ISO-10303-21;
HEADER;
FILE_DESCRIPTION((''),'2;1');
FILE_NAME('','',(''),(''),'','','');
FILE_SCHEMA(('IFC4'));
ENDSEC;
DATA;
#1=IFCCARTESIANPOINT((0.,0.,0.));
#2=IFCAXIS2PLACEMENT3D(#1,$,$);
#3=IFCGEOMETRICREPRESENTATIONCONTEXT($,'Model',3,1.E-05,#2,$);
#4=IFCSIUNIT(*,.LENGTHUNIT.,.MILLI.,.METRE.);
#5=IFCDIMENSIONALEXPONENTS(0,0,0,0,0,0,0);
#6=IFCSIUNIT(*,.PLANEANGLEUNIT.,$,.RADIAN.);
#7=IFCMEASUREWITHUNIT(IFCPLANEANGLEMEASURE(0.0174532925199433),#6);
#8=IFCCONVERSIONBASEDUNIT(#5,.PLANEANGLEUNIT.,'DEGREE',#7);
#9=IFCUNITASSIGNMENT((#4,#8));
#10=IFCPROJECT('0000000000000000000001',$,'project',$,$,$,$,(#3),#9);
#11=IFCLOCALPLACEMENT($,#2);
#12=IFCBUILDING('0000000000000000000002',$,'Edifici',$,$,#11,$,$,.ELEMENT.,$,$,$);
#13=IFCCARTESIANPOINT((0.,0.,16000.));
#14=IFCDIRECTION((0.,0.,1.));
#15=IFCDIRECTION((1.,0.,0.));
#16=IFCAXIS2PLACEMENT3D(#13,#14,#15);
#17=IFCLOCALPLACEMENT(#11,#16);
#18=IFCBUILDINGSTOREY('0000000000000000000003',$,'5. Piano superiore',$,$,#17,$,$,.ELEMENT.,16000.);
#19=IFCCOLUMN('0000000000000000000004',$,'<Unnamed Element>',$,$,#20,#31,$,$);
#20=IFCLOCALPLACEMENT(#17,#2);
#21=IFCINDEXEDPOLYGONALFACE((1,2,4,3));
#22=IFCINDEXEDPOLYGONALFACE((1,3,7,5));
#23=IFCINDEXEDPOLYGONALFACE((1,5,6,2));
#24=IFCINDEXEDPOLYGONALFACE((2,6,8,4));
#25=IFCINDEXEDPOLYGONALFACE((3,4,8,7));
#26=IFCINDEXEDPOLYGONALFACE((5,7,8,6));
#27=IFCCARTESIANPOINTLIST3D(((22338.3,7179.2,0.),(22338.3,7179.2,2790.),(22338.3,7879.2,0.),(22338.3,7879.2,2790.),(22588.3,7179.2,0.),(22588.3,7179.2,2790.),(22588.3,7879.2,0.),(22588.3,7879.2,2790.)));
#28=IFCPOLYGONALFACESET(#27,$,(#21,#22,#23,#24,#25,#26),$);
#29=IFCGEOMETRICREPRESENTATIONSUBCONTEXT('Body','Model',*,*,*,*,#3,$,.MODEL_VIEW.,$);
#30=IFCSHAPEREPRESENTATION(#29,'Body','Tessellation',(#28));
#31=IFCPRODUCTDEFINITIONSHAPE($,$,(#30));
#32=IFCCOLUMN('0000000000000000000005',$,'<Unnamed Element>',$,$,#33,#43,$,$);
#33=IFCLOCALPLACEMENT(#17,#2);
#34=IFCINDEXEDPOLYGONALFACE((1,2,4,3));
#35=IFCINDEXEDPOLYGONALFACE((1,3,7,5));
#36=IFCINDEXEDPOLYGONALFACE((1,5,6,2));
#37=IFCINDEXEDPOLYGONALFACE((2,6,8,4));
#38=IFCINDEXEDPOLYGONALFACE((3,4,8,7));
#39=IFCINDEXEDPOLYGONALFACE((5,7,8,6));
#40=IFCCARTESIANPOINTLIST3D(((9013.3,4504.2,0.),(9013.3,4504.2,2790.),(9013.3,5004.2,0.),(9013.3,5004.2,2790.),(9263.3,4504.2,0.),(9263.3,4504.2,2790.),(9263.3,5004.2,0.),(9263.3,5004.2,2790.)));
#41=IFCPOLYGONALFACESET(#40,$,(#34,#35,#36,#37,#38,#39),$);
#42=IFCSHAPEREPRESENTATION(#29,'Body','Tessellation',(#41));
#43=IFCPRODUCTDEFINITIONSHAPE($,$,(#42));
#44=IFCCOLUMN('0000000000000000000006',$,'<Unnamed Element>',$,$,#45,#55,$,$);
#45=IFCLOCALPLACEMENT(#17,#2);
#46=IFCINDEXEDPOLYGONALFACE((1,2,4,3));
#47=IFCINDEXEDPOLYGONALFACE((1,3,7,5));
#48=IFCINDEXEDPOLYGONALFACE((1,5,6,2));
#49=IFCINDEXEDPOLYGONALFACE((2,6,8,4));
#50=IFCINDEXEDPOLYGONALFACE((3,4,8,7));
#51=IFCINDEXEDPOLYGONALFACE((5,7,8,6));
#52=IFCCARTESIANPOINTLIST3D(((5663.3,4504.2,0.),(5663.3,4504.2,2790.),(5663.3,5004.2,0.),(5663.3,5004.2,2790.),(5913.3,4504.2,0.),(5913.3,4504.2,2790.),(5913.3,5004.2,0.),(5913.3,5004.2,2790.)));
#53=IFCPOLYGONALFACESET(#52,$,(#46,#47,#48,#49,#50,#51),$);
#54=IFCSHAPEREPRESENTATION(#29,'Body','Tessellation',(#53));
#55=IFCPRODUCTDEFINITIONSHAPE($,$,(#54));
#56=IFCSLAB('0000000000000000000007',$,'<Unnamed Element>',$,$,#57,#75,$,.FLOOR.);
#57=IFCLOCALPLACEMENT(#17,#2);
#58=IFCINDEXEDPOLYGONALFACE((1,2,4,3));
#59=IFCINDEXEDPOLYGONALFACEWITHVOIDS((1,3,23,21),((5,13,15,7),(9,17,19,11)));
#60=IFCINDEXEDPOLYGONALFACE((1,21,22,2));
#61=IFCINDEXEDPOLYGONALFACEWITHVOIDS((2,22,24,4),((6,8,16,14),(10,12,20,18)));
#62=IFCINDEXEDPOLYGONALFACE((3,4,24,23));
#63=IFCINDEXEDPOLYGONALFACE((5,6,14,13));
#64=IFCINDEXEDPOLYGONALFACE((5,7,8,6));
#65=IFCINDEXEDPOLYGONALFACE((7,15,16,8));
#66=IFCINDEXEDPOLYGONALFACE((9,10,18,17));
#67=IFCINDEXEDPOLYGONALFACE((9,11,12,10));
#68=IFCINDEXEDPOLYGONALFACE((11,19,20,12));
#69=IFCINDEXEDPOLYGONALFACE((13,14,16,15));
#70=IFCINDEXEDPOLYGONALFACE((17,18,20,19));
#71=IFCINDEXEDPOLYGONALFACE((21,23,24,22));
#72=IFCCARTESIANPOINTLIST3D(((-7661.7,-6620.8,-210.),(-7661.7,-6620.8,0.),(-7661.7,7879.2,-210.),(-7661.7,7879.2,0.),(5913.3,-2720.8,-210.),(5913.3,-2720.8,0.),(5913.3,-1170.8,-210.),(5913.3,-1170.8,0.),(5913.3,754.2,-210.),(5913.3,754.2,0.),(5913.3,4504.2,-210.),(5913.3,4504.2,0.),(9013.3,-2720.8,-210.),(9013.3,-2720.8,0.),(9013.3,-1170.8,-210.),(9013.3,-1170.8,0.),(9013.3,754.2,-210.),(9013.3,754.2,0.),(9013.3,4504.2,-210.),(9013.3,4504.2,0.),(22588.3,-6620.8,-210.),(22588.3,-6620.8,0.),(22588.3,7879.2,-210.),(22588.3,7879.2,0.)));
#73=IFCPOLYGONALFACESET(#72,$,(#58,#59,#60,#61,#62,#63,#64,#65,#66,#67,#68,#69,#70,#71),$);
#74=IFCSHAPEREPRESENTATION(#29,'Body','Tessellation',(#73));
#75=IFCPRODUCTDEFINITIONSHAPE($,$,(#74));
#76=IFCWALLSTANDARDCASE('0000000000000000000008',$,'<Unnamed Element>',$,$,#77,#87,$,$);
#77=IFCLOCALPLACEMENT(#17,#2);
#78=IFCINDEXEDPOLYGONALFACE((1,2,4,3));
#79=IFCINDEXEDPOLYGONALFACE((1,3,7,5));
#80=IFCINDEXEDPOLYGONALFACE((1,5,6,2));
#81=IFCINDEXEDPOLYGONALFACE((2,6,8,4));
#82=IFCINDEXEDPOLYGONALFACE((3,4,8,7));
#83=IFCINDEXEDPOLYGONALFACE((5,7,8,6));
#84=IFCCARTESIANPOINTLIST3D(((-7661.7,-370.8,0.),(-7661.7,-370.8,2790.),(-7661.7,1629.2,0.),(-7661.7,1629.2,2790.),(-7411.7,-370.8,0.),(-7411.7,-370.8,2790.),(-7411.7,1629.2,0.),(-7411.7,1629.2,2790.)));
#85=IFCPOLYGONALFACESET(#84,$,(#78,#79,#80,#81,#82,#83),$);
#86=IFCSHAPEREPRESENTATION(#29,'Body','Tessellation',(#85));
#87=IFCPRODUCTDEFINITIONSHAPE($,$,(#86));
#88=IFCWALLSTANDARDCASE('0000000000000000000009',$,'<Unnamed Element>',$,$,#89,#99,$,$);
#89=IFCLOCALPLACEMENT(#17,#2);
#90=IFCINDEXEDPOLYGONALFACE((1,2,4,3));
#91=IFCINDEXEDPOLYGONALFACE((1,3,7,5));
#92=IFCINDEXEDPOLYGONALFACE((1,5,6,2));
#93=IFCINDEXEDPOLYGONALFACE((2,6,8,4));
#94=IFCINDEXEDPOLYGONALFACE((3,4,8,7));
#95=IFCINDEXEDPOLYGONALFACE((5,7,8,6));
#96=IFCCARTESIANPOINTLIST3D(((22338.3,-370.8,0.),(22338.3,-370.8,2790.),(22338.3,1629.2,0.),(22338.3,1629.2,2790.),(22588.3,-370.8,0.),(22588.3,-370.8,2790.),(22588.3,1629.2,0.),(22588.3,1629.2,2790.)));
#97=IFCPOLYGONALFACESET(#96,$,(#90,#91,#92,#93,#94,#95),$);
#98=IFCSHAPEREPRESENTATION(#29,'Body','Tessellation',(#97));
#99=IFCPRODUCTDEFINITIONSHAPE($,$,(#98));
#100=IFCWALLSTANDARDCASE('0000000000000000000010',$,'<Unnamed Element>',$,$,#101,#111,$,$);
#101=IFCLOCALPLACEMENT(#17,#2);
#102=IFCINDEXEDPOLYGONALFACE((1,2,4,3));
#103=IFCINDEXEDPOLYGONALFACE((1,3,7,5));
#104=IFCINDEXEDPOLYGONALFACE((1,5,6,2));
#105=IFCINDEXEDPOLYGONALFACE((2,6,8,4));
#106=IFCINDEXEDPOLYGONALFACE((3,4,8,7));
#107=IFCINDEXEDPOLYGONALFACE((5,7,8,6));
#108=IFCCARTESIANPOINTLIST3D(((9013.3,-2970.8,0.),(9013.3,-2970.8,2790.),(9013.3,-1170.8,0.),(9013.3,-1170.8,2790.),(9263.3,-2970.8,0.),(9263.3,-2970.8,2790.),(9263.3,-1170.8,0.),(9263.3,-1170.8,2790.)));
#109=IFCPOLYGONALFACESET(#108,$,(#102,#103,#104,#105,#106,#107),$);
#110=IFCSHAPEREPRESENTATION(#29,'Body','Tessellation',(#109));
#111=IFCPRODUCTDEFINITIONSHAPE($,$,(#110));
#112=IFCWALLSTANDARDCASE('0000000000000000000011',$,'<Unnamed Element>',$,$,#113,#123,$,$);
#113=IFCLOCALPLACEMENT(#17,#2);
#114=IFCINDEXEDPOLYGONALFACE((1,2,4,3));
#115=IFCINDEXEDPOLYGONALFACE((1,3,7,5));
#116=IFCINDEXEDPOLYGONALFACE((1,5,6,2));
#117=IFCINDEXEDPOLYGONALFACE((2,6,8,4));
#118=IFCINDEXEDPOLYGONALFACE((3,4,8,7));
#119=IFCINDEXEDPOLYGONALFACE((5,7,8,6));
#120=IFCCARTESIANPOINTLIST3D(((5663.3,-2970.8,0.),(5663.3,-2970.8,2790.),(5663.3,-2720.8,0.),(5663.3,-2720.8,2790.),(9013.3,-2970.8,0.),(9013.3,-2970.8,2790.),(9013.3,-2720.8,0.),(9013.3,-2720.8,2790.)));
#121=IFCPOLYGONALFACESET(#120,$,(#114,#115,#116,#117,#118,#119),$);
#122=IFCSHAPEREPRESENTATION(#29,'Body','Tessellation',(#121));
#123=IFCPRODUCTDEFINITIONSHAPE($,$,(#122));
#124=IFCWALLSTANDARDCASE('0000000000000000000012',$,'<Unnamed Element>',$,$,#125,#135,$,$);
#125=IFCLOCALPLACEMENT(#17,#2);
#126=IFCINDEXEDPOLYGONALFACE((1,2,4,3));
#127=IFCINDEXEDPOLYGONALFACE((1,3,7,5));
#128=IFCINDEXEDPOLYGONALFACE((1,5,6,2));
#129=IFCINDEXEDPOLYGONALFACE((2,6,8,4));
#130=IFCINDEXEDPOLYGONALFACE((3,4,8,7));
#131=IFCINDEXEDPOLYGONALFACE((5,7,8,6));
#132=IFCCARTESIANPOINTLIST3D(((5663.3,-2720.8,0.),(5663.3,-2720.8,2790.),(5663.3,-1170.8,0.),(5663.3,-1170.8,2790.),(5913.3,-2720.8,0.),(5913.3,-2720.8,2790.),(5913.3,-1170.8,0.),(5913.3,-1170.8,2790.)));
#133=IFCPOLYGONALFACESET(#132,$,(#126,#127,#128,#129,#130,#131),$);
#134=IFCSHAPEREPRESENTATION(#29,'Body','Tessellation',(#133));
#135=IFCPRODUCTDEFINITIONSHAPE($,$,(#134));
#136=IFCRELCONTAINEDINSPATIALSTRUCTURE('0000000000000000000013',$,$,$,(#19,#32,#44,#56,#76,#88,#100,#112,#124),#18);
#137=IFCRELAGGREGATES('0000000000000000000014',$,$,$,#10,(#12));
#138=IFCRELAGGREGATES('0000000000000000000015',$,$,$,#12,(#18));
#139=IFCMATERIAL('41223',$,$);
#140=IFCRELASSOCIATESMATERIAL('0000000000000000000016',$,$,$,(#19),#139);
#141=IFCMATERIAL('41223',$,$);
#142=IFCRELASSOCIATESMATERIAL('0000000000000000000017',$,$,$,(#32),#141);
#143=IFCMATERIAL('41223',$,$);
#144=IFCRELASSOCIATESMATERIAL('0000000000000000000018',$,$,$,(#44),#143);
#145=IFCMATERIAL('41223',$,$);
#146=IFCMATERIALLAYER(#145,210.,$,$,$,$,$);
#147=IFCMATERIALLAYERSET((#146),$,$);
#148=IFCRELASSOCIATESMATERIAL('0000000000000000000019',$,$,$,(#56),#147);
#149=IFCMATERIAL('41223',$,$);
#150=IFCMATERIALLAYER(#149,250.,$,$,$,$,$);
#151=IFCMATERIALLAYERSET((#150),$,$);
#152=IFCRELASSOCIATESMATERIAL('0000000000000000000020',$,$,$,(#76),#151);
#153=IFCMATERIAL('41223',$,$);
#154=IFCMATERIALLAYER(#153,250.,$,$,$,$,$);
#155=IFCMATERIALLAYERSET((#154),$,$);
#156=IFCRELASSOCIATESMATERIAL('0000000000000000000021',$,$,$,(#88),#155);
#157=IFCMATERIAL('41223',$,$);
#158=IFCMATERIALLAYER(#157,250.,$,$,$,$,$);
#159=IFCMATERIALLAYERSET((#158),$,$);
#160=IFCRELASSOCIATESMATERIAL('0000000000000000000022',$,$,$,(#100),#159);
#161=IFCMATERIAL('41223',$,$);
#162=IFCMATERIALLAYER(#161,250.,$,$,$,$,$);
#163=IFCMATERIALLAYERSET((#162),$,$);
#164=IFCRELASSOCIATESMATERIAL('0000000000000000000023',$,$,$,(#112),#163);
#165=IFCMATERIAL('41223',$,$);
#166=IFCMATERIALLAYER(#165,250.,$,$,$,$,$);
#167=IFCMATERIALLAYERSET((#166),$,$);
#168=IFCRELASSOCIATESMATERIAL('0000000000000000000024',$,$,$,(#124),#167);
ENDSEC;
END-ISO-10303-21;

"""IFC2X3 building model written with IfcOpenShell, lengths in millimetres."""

from ifc_helpers import new_model, entity, si_unit, converted_unit, frame, frame_2d, origin, origin_with_axes, place, context, subcontext, project, spatial, polyline, rectangle, outline, extrude, material, layer, layer_set, layer_usage, element, save


model = new_model("IFC2X3")

# Units and contexts
model_context = context("Model", 3, precision=1e-05, world=origin())
body_context = subcontext(model_context, "Body", "Model", "MODEL_VIEW")
ifc_project = project(units=[si_unit("LENGTHUNIT", "METRE", prefix="MILLI"), converted_unit("PLANEANGLEUNIT", "DEGREE", entity("IfcPlaneAngleMeasure", 0.0174532925199433), si_unit("PLANEANGLEUNIT", "RADIAN"), dimensions=[0, 0, 0, 0, 0, 0, 0])], contexts=[model_context])

# Building, storey
building_placement = place(None, origin())
building = spatial("IfcBuilding", under=ifc_project, at=building_placement, Name="Edifici", CompositionType="ELEMENT")
storey_placement = place(building_placement, frame((0.0, 0.0, 16000.0), z_axis=(0.0, 0.0, 1.0), x_axis=(1.0, 0.0, 0.0)))
storey = spatial("IfcBuildingStorey", under=building, at=storey_placement, Name="5. Piano superiore", CompositionType="ELEMENT", Elevation=16000.0)

# Columns
ifc_material_1 = material(Name="41223")
column_1_placement = place(storey_placement, frame((22588.3, 7879.2, 0.0), z_axis=(0.0, 0.0, 1.0), x_axis=(1.0, 0.0, 0.0)))
element("IfcColumn", 1, at=column_1_placement, inside=storey, material=ifc_material_1, Name="<Unnamed Element>", context=body_context, shape_type="SweptSolid", body=[
    extrude(rectangle(XDim=250.0, YDim=700.0, at=frame_2d((-125.0, -350.0), x_axis=(-1.0, 0.0))), origin_with_axes(), (0.0, 0.0, 1.0), 2790.0),
])
ifc_material_2 = material(Name="41223")
column_2_placement = place(storey_placement, frame((9263.3, 5004.2, 0.0), z_axis=(0.0, 0.0, 1.0), x_axis=(1.0, 0.0, 0.0)))
element("IfcColumn", 2, at=column_2_placement, inside=storey, material=ifc_material_2, Name="<Unnamed Element>", context=body_context, shape_type="SweptSolid", body=[
    extrude(rectangle(XDim=250.0, YDim=500.0, at=frame_2d((-125.0, -250.0), x_axis=(-1.0, 0.0))), origin_with_axes(), (0.0, 0.0, 1.0), 2790.0),
])
ifc_material_3 = material(Name="41223")
column_3_placement = place(storey_placement, frame((5913.3, 5004.2, 0.0), z_axis=(0.0, 0.0, 1.0), x_axis=(1.0, 0.0, 0.0)))
element("IfcColumn", 3, at=column_3_placement, inside=storey, material=ifc_material_3, Name="<Unnamed Element>", context=body_context, shape_type="SweptSolid", body=[
    extrude(rectangle(XDim=250.0, YDim=500.0, at=frame_2d((-125.0, -250.0), x_axis=(-1.0, 0.0))), origin_with_axes(), (0.0, 0.0, 1.0), 2790.0),
])

# Slab
ifc_material_4 = material(Name="41223")
ifc_layer_1 = layer(ifc_material_4, 210.0)
ifc_layer_set_1 = layer_set([ifc_layer_1])
ifc_layer_usage_1 = layer_usage(ifc_layer_set_1, "AXIS3", "POSITIVE", 0.0)
slab_placement = place(storey_placement, frame((-7661.7, -6620.8, -210.0), z_axis=(0.0, 0.0, 1.0), x_axis=(1.0, 0.0, 0.0)))
element("IfcSlab", 4, at=slab_placement, inside=storey, material=ifc_layer_usage_1, Name="<Unnamed Element>", PredefinedType="FLOOR", context=body_context, shape_type="SweptSolid", body=[
    extrude(outline(polyline([(0.0, 0.0), (30250.0, 0.0), (30250.0, 14500.0), (0.0, 14500.0), (0.0, 0.0)]), holes=[polyline([(13575.0, 11125.0), (16675.0, 11125.0), (16675.0, 7375.0), (13575.0, 7375.0), (13575.0, 11125.0)]), polyline([(16675.0, 3900.0), (13575.0, 3900.0), (13575.0, 5450.0), (16675.0, 5450.0), (16675.0, 3900.0)])]), origin_with_axes(), (0.0, 0.0, 1.0), 210.0),
])

# Walls
ifc_material_5 = material(Name="41223")
ifc_layer_2 = layer(ifc_material_5, 250.0)
ifc_layer_set_2 = layer_set([ifc_layer_2])
ifc_layer_usage_2 = layer_usage(ifc_layer_set_2, "AXIS2", "POSITIVE", 0.0)
wall_1_placement = place(storey_placement, frame((-7661.7, 1629.2, 0.0), z_axis=(0.0, 0.0, 1.0), x_axis=(0.0, -1.0, 0.0)))
element("IfcWallStandardCase", 5, at=wall_1_placement, inside=storey, material=ifc_layer_usage_2, Name="<Unnamed Element>", context=body_context, shape_type="SweptSolid", body=[
    extrude(rectangle(XDim=2000.0, YDim=250.0, at=frame_2d((1000.0, 125.0), x_axis=(1.0, 0.0))), origin_with_axes(), (0.0, 0.0, 1.0), 2790.0),
])
ifc_material_6 = material(Name="41223")
ifc_layer_3 = layer(ifc_material_6, 250.0)
ifc_layer_set_3 = layer_set([ifc_layer_3])
ifc_layer_usage_3 = layer_usage(ifc_layer_set_3, "AXIS2", "POSITIVE", 0.0)
wall_2_placement = place(storey_placement, frame((22338.3, 1629.2, 0.0), z_axis=(0.0, 0.0, 1.0), x_axis=(0.0, -1.0, 0.0)))
element("IfcWallStandardCase", 6, at=wall_2_placement, inside=storey, material=ifc_layer_usage_3, Name="<Unnamed Element>", context=body_context, shape_type="SweptSolid", body=[
    extrude(rectangle(XDim=2000.0, YDim=250.0, at=frame_2d((1000.0, 125.0), x_axis=(1.0, 0.0))), origin_with_axes(), (0.0, 0.0, 1.0), 2790.0),
])
ifc_material_7 = material(Name="41223")
ifc_layer_4 = layer(ifc_material_7, 250.0)
ifc_layer_set_4 = layer_set([ifc_layer_4])
ifc_layer_usage_4 = layer_usage(ifc_layer_set_4, "AXIS2", "POSITIVE", 0.0)
wall_3_placement = place(storey_placement, frame((9263.3, -2970.8, 0.0), z_axis=(0.0, 0.0, 1.0), x_axis=(0.0, 1.0, 0.0)))
element("IfcWallStandardCase", 7, at=wall_3_placement, inside=storey, material=ifc_layer_usage_4, Name="<Unnamed Element>", context=body_context, shape_type="SweptSolid", body=[
    extrude(rectangle(XDim=1800.0, YDim=250.0, at=frame_2d((900.0, 125.0), x_axis=(1.0, 0.0))), origin_with_axes(), (0.0, 0.0, 1.0), 2790.0),
])
ifc_material_8 = material(Name="41223")
ifc_layer_5 = layer(ifc_material_8, 250.0)
ifc_layer_set_5 = layer_set([ifc_layer_5])
ifc_layer_usage_5 = layer_usage(ifc_layer_set_5, "AXIS2", "POSITIVE", 0.0)
wall_4_placement = place(storey_placement, frame((5663.3, -2970.8, 0.0), z_axis=(0.0, 0.0, 1.0), x_axis=(1.0, 0.0, 0.0)))
element("IfcWallStandardCase", 8, at=wall_4_placement, inside=storey, material=ifc_layer_usage_5, Name="<Unnamed Element>", context=body_context, shape_type="SweptSolid", body=[
    extrude(rectangle(XDim=3350.0, YDim=250.0, at=frame_2d((1675.0, 125.0), x_axis=(1.0, 0.0))), origin_with_axes(), (0.0, 0.0, 1.0), 2790.0),
])
ifc_material_9 = material(Name="41223")
ifc_layer_6 = layer(ifc_material_9, 250.0)
ifc_layer_set_6 = layer_set([ifc_layer_6])
ifc_layer_usage_6 = layer_usage(ifc_layer_set_6, "AXIS2", "POSITIVE", 0.0)
wall_5_placement = place(storey_placement, frame((5663.3, -1170.8, 0.0), z_axis=(0.0, 0.0, 1.0), x_axis=(0.0, -1.0, 0.0)))
element("IfcWallStandardCase", 9, at=wall_5_placement, inside=storey, material=ifc_layer_usage_6, Name="<Unnamed Element>", context=body_context, shape_type="SweptSolid", body=[
    extrude(rectangle(XDim=1550.0, YDim=250.0, at=frame_2d((775.0, 125.0), x_axis=(1.0, 0.0))), origin_with_axes(), (0.0, 0.0, 1.0), 2790.0),
])

save(model, "model.ifc")
